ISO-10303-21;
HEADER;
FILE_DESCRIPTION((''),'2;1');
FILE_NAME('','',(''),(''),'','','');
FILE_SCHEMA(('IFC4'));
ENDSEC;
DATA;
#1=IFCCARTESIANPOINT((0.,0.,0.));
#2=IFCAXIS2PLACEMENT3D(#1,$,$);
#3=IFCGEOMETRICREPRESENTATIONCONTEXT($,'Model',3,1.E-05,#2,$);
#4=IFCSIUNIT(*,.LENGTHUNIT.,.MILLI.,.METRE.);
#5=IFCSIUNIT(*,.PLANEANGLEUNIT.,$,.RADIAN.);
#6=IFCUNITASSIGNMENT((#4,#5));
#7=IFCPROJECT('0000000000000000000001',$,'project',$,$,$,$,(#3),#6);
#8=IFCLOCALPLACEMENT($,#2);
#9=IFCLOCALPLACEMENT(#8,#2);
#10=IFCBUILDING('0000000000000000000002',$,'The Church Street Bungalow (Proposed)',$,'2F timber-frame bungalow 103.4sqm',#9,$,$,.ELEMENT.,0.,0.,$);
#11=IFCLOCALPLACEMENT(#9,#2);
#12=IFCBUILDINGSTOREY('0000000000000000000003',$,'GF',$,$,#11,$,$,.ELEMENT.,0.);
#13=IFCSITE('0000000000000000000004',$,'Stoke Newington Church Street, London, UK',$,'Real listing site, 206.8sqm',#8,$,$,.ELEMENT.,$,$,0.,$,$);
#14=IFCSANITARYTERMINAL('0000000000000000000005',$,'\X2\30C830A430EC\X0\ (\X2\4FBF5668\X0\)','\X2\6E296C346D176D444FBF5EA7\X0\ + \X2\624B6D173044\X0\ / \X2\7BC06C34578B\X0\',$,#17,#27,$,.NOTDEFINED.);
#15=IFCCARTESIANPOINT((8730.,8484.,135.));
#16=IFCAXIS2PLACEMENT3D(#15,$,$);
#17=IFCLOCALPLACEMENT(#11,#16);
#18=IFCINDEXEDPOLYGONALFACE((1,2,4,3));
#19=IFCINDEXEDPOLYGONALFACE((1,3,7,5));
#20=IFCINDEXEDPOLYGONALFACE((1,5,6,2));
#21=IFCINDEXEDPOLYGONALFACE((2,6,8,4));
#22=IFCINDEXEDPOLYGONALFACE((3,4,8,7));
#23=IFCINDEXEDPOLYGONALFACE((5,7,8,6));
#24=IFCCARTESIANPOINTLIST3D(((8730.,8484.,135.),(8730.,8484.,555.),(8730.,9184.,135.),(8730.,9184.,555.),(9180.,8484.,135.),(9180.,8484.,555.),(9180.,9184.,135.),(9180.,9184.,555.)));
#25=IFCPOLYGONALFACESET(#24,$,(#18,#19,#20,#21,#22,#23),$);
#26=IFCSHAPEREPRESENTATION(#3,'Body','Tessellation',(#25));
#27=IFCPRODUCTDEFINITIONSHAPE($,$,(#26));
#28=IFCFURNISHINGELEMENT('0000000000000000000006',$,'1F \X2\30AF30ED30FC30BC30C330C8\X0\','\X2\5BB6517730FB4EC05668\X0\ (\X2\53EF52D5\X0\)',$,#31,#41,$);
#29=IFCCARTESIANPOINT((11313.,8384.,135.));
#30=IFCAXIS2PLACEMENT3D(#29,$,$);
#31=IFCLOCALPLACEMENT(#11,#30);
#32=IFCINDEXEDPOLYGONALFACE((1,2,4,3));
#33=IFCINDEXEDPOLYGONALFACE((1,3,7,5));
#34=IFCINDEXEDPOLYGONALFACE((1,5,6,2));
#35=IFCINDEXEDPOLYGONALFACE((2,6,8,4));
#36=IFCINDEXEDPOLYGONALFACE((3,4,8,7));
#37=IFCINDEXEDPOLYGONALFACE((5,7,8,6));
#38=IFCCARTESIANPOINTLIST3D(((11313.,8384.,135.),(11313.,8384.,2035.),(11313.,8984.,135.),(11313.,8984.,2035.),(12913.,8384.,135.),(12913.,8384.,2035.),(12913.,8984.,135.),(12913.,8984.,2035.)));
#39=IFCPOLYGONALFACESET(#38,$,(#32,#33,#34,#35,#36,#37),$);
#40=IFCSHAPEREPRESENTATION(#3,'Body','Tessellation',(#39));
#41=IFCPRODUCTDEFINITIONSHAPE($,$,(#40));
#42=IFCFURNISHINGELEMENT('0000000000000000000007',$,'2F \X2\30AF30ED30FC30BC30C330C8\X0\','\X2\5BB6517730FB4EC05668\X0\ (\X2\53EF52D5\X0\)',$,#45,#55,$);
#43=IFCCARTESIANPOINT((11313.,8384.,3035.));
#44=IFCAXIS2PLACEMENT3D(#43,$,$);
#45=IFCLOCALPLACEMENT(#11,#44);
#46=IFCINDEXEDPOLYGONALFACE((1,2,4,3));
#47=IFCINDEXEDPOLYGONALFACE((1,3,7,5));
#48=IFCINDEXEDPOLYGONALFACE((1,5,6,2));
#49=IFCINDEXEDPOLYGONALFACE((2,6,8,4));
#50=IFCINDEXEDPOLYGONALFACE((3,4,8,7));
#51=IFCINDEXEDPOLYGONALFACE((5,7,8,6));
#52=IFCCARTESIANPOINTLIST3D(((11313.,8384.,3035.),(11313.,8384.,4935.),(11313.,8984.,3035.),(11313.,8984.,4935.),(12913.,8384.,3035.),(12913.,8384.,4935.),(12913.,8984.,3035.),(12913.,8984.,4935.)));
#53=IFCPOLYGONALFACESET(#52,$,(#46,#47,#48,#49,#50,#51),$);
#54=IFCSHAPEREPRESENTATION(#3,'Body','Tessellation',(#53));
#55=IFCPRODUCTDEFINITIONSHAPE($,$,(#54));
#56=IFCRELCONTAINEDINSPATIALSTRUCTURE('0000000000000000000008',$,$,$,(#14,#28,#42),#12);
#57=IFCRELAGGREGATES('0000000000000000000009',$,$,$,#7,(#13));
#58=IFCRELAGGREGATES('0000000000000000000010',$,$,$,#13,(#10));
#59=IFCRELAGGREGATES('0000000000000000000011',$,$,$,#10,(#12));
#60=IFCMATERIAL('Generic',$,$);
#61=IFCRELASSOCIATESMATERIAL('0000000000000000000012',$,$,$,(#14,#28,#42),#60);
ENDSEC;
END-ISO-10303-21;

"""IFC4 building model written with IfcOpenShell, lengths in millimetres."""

from ifc_helpers import new_model, si_unit, frame, frame_2d, origin, place, context, project, spatial, rectangle, extrude, material, element, save


model = new_model("IFC4")

# Units and contexts
model_context = context("Model", 3, precision=1e-05, world=origin())
ifc_project = project(units=[si_unit("LENGTHUNIT", "METRE", prefix="MILLI"), si_unit("PLANEANGLEUNIT", "RADIAN")], contexts=[model_context])

# Site, building, storey
site_placement = place(None, origin())
site = spatial("IfcSite", under=ifc_project, at=site_placement, Name="Stoke Newington Church Street, London, UK", ObjectType="Real listing site, 206.8sqm", CompositionType="ELEMENT", RefElevation=0.0)
building_placement = place(site_placement, origin())
building = spatial("IfcBuilding", under=site, at=building_placement, Name="The Church Street Bungalow (Proposed)", ObjectType="2F timber-frame bungalow 103.4sqm", CompositionType="ELEMENT", ElevationOfRefHeight=0.0, ElevationOfTerrain=0.0)
storey_placement = place(building_placement, origin())
storey = spatial("IfcBuildingStorey", under=building, at=storey_placement, Name="GF", CompositionType="ELEMENT", Elevation=0.0)

# Shared definitions
ifc_material_1 = material(Name="Generic")

# Sanitary terminal
sanitary_terminal_1_placement = place(storey_placement, frame((8730.0, 8484.0, 135.0)))
element("IfcSanitaryTerminal", 1, at=sanitary_terminal_1_placement, inside=storey, material=ifc_material_1, Name="トイレ (便器)", Description="温水洗浄便座 + 手洗い / 節水型", PredefinedType="NOTDEFINED", context=model_context, shape_type="SweptSolid", body=[
    extrude(rectangle(XDim=450.0, YDim=700.0, at=frame_2d((225.0, 350.0))), frame((8730.0, 8484.0, 135.0)), (0.0, 0.0, 1.0), 420.0),
])

# Furnishing elements
furnishing_1_placement = place(storey_placement, frame((11313.0, 8384.0, 135.0)))
element("IfcFurnishingElement", 2, at=furnishing_1_placement, inside=storey, material=ifc_material_1, Name="1F クローゼット", Description="家具・什器 (可動)", context=model_context, shape_type="SweptSolid", body=[
    extrude(rectangle(XDim=1600.0, YDim=600.0, at=frame_2d((800.0, 300.0))), frame((11313.0, 8384.0, 135.0)), (0.0, 0.0, 1.0), 1900.0),
])
furnishing_2_placement = place(storey_placement, frame((11313.0, 8384.0, 3035.0)))
element("IfcFurnishingElement", 3, at=furnishing_2_placement, inside=storey, material=ifc_material_1, Name="2F クローゼット", Description="家具・什器 (可動)", context=model_context, shape_type="SweptSolid", body=[
    extrude(rectangle(XDim=1600.0, YDim=600.0, at=frame_2d((800.0, 300.0))), frame((11313.0, 8384.0, 3035.0)), (0.0, 0.0, 1.0), 1900.0),
])

save(model, "model.ifc")
